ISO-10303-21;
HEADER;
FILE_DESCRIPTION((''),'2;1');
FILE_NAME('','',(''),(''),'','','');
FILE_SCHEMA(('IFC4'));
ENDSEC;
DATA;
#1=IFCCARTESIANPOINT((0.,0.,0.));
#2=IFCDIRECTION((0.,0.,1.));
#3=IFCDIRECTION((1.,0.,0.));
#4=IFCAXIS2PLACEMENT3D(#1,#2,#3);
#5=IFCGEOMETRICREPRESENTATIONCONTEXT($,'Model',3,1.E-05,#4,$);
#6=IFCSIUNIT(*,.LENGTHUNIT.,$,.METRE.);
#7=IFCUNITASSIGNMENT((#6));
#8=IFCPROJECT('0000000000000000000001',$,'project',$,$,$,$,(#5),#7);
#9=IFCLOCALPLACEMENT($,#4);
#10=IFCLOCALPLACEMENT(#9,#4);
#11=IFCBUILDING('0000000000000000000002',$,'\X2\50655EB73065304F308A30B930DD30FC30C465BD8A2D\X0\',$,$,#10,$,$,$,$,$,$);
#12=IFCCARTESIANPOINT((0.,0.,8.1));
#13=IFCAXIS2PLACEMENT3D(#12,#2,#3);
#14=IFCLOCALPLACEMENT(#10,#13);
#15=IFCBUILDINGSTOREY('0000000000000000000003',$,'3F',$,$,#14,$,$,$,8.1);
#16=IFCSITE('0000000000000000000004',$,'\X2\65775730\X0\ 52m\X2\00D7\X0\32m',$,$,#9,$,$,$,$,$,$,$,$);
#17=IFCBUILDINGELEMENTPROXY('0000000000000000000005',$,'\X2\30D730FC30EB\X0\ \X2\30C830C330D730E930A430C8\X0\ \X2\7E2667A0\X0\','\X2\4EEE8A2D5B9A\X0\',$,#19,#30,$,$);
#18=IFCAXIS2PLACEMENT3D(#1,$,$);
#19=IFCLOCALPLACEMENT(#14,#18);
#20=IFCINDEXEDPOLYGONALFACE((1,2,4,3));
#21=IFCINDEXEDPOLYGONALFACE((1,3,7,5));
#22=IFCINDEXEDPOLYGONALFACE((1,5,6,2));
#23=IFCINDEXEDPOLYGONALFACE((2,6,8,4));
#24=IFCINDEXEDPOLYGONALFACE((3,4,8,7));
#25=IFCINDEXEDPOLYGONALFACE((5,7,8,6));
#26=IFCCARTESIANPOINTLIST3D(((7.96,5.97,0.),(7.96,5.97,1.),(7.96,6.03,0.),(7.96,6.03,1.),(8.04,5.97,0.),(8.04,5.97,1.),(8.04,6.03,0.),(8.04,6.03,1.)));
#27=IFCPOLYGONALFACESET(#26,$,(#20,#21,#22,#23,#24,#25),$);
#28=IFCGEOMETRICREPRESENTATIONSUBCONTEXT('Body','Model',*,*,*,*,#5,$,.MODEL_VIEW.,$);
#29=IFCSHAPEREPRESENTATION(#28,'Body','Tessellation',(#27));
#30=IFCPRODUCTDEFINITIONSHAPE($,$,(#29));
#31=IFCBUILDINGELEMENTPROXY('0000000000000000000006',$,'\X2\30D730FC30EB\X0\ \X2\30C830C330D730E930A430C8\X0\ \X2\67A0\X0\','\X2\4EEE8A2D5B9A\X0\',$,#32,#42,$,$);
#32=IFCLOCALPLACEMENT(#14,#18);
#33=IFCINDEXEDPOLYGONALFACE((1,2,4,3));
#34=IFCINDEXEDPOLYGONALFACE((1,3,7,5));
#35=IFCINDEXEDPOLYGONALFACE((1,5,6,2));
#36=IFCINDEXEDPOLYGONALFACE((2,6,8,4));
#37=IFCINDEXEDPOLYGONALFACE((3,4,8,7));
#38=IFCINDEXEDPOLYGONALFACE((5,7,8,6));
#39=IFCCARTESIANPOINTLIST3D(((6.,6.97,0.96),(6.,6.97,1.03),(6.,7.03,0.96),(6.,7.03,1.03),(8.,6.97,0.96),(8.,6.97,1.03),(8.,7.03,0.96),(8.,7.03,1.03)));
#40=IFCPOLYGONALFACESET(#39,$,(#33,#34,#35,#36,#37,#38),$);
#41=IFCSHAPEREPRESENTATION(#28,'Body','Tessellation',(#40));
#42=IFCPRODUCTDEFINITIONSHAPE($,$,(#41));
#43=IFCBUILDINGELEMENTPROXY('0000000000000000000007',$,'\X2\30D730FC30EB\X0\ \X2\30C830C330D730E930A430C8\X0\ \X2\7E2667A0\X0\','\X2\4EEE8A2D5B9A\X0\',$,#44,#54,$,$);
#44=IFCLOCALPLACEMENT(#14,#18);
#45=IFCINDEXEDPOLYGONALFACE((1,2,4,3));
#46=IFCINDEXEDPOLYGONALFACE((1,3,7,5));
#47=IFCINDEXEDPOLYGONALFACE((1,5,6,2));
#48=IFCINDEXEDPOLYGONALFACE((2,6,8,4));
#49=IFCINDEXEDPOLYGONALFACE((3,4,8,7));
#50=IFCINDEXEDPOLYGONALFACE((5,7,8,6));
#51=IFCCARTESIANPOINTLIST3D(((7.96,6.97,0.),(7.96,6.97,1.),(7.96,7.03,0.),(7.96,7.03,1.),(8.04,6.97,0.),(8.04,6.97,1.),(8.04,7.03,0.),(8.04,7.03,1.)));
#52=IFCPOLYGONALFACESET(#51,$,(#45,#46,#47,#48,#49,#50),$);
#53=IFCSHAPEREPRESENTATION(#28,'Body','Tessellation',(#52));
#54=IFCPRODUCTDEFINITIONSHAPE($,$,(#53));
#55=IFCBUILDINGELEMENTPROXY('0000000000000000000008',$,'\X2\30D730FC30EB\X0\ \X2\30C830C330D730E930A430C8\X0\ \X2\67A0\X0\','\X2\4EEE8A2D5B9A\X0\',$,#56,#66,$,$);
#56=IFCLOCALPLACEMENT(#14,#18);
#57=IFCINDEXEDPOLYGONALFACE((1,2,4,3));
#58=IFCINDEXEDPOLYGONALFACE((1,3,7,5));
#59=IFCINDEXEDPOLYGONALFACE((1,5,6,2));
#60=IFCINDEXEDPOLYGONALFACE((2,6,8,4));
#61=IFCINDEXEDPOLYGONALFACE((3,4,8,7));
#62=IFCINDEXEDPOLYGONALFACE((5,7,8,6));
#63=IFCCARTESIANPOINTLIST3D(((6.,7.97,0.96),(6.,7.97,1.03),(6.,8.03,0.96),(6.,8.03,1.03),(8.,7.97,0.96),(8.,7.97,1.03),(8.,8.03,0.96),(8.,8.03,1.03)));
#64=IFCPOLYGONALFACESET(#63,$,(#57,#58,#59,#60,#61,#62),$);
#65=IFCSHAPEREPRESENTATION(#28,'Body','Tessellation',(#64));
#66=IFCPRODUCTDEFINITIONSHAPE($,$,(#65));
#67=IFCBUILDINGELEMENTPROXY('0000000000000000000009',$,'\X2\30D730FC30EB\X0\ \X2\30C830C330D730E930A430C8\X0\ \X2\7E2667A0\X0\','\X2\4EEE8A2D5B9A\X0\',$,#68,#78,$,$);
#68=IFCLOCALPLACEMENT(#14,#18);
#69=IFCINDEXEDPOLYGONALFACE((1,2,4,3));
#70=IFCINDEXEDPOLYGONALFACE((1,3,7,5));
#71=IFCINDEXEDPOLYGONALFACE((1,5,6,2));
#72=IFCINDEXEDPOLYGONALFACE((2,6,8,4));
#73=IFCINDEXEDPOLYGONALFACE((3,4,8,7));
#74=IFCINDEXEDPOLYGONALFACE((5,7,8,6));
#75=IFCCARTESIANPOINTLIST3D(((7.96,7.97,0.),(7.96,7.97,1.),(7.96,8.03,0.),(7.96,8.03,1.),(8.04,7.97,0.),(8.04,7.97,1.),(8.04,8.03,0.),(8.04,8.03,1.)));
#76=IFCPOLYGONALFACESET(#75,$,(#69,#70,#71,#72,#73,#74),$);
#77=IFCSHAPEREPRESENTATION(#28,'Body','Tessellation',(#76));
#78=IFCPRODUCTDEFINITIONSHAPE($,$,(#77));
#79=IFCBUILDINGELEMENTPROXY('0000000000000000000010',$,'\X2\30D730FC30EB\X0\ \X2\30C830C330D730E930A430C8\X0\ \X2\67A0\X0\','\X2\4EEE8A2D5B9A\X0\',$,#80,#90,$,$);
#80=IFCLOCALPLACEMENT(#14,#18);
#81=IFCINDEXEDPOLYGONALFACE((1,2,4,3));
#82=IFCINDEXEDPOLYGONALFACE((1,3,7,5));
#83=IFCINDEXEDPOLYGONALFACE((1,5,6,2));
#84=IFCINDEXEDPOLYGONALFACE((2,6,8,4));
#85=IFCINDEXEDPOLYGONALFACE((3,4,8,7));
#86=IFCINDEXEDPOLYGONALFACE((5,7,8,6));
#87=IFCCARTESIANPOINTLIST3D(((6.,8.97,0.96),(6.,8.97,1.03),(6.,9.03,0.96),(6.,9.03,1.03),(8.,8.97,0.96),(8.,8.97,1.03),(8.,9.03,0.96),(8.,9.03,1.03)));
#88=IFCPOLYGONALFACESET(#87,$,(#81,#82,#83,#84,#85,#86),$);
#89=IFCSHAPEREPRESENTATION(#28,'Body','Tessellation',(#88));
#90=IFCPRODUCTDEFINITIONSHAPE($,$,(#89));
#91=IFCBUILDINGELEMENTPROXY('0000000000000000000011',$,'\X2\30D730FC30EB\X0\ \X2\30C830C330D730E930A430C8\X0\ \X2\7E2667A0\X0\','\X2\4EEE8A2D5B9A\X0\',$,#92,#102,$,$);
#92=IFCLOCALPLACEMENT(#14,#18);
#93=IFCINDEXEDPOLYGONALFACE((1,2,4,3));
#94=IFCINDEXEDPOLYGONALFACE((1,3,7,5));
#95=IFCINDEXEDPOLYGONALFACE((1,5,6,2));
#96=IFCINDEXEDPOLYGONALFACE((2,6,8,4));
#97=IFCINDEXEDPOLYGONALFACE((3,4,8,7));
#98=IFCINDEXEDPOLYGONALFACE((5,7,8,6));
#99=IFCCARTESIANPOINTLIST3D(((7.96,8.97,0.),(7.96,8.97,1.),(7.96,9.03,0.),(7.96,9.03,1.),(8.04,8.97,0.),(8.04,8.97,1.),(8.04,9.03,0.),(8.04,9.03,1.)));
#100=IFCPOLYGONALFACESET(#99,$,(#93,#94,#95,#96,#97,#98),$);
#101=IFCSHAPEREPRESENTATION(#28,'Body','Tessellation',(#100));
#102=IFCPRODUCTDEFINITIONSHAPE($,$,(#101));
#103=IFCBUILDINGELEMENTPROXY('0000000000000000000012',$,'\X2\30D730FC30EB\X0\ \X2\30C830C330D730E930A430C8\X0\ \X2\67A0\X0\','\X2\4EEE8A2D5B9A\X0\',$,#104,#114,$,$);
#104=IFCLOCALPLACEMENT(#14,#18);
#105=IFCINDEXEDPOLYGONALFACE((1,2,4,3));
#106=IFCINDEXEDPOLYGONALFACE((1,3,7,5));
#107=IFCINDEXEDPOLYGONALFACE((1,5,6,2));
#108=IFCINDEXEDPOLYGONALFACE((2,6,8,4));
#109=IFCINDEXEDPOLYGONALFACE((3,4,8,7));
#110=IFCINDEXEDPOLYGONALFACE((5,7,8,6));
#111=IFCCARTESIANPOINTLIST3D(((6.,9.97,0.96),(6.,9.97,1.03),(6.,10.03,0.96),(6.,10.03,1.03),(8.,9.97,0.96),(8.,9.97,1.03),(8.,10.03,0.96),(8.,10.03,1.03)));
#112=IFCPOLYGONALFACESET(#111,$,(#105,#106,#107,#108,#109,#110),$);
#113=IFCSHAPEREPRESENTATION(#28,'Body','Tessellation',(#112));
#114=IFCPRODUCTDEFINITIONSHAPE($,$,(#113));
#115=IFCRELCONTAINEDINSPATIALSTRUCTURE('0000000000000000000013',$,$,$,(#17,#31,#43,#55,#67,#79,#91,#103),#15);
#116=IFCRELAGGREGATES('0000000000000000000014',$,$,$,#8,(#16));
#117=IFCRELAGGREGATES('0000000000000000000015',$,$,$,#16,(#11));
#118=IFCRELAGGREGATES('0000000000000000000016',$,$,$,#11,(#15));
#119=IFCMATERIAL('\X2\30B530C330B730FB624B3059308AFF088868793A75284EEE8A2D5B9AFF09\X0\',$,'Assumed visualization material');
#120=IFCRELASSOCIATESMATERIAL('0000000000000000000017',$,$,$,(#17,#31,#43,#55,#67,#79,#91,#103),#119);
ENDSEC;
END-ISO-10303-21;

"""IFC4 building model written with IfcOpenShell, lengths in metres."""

from ifc_helpers import new_model, si_unit, frame, origin_with_axes, place, context, subcontext, project, spatial, rectangle, extrude, material, element, save


model = new_model("IFC4")

# Units and contexts
model_context = context("Model", 3, precision=1e-05, world=origin_with_axes())
body_context = subcontext(model_context, "Body", "Model", "MODEL_VIEW")
ifc_project = project(units=[si_unit("LENGTHUNIT", "METRE")], contexts=[model_context])

# Site, building, storey
site_placement = place(None, origin_with_axes())
site = spatial("IfcSite", under=ifc_project, at=site_placement, Name="敷地 52m×32m")
building_placement = place(site_placement, origin_with_axes())
building = spatial("IfcBuilding", under=site, at=building_placement, Name="健康づくりスポーツ施設")
storey_placement = place(building_placement, frame((0.0, 0.0, 8.1), z_axis=(0.0, 0.0, 1.0), x_axis=(1.0, 0.0, 0.0)))
storey = spatial("IfcBuildingStorey", under=building, at=storey_placement, Name="3F", Elevation=8.1)

# Building element proxies
ifc_material_1 = material(Name="サッシ・手すり（表示用仮設定）", Category="Assumed visualization material")
proxy_1_placement = place(storey_placement, frame((8.0, 6.0, 0.0), z_axis=(0.0, 0.0, 1.0), x_axis=(1.0, 0.0, 0.0)))
element("IfcBuildingElementProxy", 1, at=proxy_1_placement, inside=storey, material=ifc_material_1, Name="プール トップライト 縦枠", Description="仮設定", context=body_context, shape_type="SweptSolid", body=[
    extrude(rectangle(XDim=0.08, YDim=0.06), origin_with_axes(), (0.0, 0.0, 1.0), 1.0),
])
proxy_2_placement = place(storey_placement, frame((7.0, 7.0, 0.96), z_axis=(0.0, 0.0, 1.0), x_axis=(1.0, 0.0, 0.0)))
element("IfcBuildingElementProxy", 2, at=proxy_2_placement, inside=storey, material=ifc_material_1, Name="プール トップライト 枠", Description="仮設定", context=body_context, shape_type="SweptSolid", body=[
    extrude(rectangle(XDim=2.0, YDim=0.06), origin_with_axes(), (0.0, 0.0, 1.0), 0.07),
])
proxy_3_placement = place(storey_placement, frame((8.0, 7.0, 0.0), z_axis=(0.0, 0.0, 1.0), x_axis=(1.0, 0.0, 0.0)))
element("IfcBuildingElementProxy", 3, at=proxy_3_placement, inside=storey, material=ifc_material_1, Name="プール トップライト 縦枠", Description="仮設定", context=body_context, shape_type="SweptSolid", body=[
    extrude(rectangle(XDim=0.08, YDim=0.06), origin_with_axes(), (0.0, 0.0, 1.0), 1.0),
])
proxy_4_placement = place(storey_placement, frame((7.0, 8.0, 0.96), z_axis=(0.0, 0.0, 1.0), x_axis=(1.0, 0.0, 0.0)))
element("IfcBuildingElementProxy", 4, at=proxy_4_placement, inside=storey, material=ifc_material_1, Name="プール トップライト 枠", Description="仮設定", context=body_context, shape_type="SweptSolid", body=[
    extrude(rectangle(XDim=2.0, YDim=0.06), origin_with_axes(), (0.0, 0.0, 1.0), 0.07),
])
proxy_5_placement = place(storey_placement, frame((8.0, 8.0, 0.0), z_axis=(0.0, 0.0, 1.0), x_axis=(1.0, 0.0, 0.0)))
element("IfcBuildingElementProxy", 5, at=proxy_5_placement, inside=storey, material=ifc_material_1, Name="プール トップライト 縦枠", Description="仮設定", context=body_context, shape_type="SweptSolid", body=[
    extrude(rectangle(XDim=0.08, YDim=0.06), origin_with_axes(), (0.0, 0.0, 1.0), 1.0),
])
proxy_6_placement = place(storey_placement, frame((7.0, 9.0, 0.96), z_axis=(0.0, 0.0, 1.0), x_axis=(1.0, 0.0, 0.0)))
element("IfcBuildingElementProxy", 6, at=proxy_6_placement, inside=storey, material=ifc_material_1, Name="プール トップライト 枠", Description="仮設定", context=body_context, shape_type="SweptSolid", body=[
    extrude(rectangle(XDim=2.0, YDim=0.06), origin_with_axes(), (0.0, 0.0, 1.0), 0.07),
])
proxy_7_placement = place(storey_placement, frame((8.0, 9.0, 0.0), z_axis=(0.0, 0.0, 1.0), x_axis=(1.0, 0.0, 0.0)))
element("IfcBuildingElementProxy", 7, at=proxy_7_placement, inside=storey, material=ifc_material_1, Name="プール トップライト 縦枠", Description="仮設定", context=body_context, shape_type="SweptSolid", body=[
    extrude(rectangle(XDim=0.08, YDim=0.06), origin_with_axes(), (0.0, 0.0, 1.0), 1.0),
])
proxy_8_placement = place(storey_placement, frame((7.0, 10.0, 0.96), z_axis=(0.0, 0.0, 1.0), x_axis=(1.0, 0.0, 0.0)))
element("IfcBuildingElementProxy", 8, at=proxy_8_placement, inside=storey, material=ifc_material_1, Name="プール トップライト 枠", Description="仮設定", context=body_context, shape_type="SweptSolid", body=[
    extrude(rectangle(XDim=2.0, YDim=0.06), origin_with_axes(), (0.0, 0.0, 1.0), 0.07),
])

save(model, "model.ifc")
